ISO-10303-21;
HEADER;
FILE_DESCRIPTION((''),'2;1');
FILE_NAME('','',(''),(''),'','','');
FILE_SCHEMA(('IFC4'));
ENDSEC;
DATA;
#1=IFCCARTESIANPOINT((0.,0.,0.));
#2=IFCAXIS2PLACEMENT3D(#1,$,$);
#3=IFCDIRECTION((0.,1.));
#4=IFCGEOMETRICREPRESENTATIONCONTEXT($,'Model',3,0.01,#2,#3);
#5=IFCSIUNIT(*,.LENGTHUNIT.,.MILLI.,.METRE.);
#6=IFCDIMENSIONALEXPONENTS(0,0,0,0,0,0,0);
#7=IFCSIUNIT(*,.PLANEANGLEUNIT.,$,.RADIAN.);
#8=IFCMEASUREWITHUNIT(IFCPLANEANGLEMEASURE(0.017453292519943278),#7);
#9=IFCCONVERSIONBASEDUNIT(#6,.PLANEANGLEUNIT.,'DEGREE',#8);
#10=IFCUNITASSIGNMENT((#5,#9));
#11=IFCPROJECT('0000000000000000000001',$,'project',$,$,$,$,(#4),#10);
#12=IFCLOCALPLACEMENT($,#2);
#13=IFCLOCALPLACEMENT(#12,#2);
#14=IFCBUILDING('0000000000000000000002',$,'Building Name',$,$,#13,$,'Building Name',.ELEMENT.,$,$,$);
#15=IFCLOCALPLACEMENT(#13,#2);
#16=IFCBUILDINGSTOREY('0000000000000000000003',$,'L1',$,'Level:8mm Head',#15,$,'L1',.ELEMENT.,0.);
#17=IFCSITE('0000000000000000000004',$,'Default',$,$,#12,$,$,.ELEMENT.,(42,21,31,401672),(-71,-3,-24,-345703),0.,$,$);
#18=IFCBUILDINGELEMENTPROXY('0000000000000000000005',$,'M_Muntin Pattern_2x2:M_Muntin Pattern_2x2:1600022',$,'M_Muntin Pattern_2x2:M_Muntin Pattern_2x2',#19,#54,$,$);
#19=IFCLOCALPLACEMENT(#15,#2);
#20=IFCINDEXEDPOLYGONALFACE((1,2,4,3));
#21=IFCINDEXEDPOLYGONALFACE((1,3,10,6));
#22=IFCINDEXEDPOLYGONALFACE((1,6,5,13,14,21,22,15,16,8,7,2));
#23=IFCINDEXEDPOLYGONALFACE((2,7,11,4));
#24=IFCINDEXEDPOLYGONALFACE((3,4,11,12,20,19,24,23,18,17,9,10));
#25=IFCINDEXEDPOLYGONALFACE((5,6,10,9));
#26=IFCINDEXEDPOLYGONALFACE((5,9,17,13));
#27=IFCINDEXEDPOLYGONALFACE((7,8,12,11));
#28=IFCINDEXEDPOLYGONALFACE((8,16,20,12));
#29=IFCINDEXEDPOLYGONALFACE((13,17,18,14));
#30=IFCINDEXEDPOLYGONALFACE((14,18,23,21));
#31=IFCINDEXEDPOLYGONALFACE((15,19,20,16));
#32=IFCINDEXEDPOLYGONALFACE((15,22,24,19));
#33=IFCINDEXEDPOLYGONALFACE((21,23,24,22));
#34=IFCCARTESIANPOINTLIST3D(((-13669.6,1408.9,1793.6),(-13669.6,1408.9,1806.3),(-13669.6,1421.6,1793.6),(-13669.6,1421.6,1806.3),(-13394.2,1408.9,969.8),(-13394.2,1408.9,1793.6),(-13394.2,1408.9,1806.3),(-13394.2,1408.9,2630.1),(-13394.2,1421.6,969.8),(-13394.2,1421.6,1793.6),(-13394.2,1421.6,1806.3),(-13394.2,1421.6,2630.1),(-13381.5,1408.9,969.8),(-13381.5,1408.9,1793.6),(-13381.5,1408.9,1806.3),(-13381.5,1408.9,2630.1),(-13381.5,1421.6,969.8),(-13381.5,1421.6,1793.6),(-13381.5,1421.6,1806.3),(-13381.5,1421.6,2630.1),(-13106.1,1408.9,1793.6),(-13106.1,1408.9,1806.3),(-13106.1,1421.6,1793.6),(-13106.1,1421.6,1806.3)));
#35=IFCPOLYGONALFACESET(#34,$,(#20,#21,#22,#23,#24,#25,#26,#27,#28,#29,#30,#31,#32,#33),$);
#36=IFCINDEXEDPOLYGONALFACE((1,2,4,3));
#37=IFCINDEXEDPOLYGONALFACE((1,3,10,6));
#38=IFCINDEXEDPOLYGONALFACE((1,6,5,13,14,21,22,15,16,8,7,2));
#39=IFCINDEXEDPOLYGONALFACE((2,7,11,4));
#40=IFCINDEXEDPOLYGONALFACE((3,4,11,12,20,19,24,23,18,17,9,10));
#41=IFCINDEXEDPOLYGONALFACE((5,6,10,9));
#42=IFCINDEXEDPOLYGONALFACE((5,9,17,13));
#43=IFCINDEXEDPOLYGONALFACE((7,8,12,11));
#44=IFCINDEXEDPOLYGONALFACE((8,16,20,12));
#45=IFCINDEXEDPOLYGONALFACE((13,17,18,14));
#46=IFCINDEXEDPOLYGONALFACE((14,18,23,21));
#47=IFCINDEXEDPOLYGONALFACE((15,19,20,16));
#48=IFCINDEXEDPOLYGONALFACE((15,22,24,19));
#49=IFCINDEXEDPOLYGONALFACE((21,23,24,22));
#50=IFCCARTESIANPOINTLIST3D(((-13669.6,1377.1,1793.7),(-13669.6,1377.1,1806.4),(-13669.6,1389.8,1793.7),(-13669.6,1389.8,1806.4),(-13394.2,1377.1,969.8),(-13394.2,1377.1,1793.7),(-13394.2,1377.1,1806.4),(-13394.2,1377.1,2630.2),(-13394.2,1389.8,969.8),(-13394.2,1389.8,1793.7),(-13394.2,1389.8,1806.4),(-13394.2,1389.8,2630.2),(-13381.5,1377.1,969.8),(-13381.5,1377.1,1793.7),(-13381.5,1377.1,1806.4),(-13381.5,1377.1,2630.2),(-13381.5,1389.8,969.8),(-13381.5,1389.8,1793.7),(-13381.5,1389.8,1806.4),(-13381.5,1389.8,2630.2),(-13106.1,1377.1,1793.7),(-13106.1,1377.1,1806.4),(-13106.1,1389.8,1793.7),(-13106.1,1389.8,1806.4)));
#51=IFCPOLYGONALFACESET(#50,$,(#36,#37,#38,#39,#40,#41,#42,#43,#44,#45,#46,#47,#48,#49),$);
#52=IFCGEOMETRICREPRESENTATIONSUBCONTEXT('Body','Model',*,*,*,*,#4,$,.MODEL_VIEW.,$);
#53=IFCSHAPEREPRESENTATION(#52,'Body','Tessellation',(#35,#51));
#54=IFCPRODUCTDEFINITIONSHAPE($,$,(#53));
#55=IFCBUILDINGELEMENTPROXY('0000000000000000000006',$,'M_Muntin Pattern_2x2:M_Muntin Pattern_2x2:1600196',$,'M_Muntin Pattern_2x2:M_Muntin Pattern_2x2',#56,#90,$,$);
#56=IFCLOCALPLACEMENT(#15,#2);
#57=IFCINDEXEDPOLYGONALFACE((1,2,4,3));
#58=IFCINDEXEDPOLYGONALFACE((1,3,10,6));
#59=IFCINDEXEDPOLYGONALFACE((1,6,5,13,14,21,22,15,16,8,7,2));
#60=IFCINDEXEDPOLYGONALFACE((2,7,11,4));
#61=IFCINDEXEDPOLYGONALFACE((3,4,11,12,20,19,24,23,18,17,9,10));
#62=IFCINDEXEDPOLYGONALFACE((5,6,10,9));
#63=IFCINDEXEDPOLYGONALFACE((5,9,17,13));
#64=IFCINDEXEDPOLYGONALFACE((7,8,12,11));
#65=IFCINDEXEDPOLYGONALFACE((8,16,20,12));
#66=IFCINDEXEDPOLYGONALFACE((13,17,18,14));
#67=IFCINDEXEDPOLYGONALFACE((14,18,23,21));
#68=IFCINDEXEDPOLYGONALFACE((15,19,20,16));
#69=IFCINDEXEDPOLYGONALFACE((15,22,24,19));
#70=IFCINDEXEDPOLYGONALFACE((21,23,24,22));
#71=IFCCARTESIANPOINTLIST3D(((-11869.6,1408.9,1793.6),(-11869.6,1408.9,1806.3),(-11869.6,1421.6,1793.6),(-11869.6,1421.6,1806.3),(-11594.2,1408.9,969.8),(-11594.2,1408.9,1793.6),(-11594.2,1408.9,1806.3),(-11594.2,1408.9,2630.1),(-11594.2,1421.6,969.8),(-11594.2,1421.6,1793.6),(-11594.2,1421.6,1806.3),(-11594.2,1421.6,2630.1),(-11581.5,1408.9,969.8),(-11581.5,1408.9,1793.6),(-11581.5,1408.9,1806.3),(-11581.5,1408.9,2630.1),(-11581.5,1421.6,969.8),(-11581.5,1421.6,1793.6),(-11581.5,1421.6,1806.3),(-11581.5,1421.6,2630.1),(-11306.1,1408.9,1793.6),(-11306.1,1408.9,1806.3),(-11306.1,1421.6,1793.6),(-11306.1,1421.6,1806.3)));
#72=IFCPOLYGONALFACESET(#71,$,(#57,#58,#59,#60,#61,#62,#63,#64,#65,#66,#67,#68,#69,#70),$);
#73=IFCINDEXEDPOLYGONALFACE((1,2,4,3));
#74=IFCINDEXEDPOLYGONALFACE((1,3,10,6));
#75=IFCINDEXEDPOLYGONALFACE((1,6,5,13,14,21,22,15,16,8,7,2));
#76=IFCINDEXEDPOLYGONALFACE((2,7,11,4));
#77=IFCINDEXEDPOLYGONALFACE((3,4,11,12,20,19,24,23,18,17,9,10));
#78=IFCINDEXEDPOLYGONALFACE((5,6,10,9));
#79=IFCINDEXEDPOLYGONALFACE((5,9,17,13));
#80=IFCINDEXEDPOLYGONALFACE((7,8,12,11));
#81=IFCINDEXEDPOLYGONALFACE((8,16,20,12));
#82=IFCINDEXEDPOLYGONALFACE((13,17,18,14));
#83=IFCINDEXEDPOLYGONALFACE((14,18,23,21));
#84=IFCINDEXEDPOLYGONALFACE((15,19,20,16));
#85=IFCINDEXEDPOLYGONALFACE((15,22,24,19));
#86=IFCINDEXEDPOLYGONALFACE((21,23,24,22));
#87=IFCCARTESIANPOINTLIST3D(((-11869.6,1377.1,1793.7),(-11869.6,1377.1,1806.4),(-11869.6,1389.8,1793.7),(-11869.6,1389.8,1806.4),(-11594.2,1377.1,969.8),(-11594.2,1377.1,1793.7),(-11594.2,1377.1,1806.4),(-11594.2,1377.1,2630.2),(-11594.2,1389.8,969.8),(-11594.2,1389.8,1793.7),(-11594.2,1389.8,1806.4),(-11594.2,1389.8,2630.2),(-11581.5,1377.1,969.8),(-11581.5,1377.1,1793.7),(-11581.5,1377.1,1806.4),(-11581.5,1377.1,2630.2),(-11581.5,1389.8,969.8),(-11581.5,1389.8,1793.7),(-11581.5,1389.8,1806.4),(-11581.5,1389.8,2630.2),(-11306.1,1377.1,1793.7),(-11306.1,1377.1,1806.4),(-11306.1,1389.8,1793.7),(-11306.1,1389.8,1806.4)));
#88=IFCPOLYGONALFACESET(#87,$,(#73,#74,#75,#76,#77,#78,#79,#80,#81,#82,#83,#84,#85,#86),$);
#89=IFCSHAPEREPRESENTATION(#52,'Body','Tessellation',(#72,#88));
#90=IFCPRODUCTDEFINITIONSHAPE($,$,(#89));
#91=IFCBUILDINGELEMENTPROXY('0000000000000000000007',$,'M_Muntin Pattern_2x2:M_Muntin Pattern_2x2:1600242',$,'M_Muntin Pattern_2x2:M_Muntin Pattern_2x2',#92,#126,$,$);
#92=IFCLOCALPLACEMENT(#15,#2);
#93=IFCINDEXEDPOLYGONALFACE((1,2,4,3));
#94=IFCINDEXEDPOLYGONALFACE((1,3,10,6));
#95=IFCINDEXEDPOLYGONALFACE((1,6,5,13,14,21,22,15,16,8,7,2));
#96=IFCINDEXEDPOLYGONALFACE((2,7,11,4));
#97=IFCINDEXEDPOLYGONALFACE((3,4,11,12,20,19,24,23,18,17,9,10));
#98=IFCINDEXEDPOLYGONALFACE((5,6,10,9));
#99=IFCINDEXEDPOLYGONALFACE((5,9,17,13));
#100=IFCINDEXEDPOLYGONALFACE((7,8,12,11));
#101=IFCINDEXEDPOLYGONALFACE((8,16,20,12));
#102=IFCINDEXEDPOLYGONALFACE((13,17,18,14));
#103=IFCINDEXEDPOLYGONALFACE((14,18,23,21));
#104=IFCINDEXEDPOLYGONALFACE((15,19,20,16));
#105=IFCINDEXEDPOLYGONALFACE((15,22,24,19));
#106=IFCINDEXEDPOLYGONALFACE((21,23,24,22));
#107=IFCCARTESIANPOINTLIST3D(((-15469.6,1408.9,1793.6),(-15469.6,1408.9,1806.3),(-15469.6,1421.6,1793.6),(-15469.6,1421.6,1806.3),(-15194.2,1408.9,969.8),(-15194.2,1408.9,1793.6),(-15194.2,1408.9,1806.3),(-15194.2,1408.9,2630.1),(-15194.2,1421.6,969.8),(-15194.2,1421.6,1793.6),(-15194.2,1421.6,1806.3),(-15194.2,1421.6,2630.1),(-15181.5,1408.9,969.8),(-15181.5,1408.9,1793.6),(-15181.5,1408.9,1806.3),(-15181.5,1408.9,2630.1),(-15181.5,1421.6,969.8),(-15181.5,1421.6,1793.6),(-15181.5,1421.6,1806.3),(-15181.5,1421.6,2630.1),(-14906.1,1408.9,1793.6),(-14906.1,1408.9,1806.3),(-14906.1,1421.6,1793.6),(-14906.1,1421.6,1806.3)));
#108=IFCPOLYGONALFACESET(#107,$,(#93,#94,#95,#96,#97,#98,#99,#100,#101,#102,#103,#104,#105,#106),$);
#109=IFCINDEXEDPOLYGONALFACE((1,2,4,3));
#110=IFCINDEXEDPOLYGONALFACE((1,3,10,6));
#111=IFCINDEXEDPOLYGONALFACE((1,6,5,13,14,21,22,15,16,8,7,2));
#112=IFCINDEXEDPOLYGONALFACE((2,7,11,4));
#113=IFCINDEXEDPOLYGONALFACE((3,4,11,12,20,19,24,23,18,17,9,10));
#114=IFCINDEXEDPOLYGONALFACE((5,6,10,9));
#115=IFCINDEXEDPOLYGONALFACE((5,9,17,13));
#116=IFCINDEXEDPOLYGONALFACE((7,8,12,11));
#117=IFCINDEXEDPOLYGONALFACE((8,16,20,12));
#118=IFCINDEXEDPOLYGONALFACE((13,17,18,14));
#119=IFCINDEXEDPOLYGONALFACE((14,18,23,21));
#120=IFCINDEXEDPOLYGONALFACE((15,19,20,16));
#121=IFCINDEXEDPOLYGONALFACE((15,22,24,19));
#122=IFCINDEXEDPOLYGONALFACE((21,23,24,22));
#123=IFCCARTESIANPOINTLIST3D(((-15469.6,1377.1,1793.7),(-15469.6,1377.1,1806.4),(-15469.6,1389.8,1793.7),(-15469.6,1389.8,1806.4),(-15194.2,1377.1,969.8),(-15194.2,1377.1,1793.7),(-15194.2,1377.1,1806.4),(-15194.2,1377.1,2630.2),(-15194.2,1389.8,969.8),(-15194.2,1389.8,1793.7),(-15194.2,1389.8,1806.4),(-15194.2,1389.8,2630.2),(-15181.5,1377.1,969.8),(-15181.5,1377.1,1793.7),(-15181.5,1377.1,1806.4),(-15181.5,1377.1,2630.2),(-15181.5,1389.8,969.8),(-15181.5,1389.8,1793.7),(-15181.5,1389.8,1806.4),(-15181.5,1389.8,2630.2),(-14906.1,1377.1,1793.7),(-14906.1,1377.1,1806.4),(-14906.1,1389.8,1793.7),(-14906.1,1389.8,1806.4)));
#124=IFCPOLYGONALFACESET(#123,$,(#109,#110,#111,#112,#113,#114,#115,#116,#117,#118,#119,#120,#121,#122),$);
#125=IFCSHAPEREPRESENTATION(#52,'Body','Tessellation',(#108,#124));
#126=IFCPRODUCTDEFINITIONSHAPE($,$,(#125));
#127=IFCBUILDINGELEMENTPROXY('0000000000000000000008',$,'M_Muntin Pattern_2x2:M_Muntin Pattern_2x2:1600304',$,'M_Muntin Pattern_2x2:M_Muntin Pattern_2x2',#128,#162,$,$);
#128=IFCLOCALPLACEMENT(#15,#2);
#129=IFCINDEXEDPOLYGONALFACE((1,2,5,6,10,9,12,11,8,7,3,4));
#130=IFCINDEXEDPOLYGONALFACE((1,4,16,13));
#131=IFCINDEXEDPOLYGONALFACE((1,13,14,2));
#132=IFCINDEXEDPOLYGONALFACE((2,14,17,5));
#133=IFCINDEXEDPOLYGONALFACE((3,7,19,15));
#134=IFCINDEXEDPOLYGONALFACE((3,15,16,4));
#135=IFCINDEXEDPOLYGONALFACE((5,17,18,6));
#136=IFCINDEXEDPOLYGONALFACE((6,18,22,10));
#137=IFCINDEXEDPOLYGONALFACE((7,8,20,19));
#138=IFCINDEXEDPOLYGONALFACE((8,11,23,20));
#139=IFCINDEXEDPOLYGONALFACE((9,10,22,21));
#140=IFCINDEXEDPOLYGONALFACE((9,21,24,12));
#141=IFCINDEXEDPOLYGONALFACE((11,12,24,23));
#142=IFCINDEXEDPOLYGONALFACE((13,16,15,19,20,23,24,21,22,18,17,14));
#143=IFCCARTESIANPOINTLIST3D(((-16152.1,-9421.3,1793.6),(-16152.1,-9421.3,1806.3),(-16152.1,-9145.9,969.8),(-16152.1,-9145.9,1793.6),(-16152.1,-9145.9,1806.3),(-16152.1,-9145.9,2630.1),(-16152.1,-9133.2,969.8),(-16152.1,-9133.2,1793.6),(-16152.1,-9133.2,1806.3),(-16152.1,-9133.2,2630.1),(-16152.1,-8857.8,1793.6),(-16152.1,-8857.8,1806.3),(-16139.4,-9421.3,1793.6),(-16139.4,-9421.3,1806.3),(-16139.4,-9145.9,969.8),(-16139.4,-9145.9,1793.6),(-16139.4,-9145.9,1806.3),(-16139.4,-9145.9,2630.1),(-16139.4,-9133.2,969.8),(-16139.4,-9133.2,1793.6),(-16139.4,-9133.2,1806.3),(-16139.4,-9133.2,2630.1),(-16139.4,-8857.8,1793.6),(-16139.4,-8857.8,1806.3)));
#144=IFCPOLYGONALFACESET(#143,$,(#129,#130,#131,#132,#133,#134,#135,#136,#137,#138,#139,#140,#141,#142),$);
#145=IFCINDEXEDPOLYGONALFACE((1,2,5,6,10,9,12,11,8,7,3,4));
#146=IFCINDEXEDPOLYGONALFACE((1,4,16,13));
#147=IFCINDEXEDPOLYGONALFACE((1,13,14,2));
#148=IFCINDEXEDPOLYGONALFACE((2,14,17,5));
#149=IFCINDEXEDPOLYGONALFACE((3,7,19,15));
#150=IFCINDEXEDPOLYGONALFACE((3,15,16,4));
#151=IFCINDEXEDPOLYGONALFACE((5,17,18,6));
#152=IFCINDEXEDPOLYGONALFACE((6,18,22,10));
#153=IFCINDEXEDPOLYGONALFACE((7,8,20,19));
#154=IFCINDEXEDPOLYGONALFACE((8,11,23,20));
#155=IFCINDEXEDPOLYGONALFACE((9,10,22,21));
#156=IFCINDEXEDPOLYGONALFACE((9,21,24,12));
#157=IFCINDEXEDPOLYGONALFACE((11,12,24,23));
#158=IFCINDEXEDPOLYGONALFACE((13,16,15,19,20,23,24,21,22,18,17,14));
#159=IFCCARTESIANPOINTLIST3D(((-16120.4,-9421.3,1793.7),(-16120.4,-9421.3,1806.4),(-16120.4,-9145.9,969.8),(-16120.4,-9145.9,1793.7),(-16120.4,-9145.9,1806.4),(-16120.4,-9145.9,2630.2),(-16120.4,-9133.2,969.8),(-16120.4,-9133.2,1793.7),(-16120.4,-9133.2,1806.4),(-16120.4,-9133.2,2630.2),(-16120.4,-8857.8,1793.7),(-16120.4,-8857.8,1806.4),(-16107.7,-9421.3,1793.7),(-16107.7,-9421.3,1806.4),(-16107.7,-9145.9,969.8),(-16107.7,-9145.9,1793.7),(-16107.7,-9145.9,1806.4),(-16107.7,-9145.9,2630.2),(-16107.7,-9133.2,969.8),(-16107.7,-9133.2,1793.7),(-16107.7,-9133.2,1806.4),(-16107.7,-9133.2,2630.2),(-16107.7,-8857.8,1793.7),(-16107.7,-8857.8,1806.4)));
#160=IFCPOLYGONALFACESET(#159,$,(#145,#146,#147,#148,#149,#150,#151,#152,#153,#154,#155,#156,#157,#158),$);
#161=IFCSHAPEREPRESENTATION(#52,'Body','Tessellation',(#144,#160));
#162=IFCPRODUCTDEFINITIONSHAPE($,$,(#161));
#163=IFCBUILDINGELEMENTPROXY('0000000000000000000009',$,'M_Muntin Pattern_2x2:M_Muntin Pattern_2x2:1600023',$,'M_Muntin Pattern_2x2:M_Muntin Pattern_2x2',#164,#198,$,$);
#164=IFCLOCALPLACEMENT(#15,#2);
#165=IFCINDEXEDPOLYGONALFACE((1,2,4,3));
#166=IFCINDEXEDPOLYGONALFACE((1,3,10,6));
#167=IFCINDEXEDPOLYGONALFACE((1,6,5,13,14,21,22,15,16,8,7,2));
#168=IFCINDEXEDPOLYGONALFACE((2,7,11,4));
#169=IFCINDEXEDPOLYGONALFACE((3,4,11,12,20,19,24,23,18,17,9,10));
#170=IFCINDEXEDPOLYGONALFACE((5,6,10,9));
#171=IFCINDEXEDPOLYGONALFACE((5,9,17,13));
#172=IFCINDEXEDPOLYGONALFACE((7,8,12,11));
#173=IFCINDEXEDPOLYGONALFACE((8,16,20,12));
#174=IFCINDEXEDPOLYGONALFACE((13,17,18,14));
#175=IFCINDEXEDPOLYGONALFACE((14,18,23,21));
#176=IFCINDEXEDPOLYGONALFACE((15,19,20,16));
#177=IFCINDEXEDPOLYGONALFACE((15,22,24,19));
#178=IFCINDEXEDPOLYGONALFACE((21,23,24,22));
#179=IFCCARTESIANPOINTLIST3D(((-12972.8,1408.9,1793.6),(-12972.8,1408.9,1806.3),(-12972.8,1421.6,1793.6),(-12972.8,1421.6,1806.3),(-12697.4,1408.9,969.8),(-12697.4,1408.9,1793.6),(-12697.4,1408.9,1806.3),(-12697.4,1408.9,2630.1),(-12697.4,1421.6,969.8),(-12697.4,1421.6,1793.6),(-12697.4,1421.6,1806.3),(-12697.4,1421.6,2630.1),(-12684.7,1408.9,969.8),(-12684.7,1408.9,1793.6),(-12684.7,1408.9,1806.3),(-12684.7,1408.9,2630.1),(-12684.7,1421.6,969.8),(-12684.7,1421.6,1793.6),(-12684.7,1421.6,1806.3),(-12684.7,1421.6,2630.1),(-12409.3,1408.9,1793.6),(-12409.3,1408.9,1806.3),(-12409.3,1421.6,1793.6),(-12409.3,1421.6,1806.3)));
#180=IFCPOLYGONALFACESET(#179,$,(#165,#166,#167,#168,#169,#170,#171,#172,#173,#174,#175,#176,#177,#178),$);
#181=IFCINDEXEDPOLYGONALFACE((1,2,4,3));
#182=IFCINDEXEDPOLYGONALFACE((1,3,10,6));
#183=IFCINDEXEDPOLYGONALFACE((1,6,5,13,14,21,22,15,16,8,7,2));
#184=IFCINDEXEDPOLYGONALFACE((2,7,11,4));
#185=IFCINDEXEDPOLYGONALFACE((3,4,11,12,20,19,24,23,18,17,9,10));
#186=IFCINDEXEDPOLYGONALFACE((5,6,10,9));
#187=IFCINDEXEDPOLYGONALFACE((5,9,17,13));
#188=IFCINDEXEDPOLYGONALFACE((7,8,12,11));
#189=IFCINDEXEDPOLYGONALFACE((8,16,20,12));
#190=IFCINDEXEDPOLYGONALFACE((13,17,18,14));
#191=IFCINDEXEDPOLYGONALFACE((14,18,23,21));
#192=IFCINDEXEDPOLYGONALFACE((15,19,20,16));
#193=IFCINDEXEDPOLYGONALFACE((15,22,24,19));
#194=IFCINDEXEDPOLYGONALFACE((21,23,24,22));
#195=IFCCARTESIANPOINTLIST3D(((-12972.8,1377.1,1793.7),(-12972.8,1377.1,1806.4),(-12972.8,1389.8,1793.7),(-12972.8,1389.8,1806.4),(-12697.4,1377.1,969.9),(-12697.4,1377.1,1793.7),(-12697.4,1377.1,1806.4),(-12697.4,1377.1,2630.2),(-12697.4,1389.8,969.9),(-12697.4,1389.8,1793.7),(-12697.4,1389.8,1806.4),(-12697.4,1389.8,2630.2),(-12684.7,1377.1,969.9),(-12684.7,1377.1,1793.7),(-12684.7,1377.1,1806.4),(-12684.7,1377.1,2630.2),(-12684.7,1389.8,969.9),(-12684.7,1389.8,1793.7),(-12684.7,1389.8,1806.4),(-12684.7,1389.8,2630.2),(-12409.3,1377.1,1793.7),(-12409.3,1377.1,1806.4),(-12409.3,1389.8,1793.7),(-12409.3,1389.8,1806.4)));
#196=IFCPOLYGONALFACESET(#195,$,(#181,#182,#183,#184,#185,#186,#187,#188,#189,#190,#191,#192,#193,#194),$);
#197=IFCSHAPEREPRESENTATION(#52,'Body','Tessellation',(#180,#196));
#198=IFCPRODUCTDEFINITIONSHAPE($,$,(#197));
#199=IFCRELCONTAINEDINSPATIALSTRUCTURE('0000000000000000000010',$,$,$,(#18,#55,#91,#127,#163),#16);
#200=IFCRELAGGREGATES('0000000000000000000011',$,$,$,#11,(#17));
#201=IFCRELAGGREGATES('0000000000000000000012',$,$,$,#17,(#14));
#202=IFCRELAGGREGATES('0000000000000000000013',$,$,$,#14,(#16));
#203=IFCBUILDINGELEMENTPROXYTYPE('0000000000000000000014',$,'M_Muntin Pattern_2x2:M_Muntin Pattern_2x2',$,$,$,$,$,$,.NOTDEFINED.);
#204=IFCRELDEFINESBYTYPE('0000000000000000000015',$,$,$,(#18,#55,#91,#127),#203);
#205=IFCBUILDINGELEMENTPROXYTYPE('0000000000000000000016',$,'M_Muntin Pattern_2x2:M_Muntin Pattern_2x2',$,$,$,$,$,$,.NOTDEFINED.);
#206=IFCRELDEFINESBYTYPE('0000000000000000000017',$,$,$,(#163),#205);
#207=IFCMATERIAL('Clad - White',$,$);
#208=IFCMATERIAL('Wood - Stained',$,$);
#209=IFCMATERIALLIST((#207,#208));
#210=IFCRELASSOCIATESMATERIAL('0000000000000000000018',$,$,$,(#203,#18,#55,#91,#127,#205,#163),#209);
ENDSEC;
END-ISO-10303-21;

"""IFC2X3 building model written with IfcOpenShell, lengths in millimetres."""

from ifc_helpers import new_model, entity, si_unit, converted_unit, direction, frame, origin, place, context, subcontext, project, spatial, polyline, outline, extrude, source, transform, mapped, material, material_list, type_object, type_shapes, element, save


model = new_model("IFC2X3")

# Units and contexts
model_context = context("Model", 3, precision=0.01, world=origin(), true_north=direction((0.0, 1.0)))
body_context = subcontext(model_context, "Body", "Model", "MODEL_VIEW")
ifc_project = project(units=[si_unit("LENGTHUNIT", "METRE", prefix="MILLI"), converted_unit("PLANEANGLEUNIT", "DEGREE", entity("IfcPlaneAngleMeasure", 0.017453292519943278), si_unit("PLANEANGLEUNIT", "RADIAN"), dimensions=[0, 0, 0, 0, 0, 0, 0])], contexts=[model_context])

# Site, building, storey
site_placement = place(None, origin())
site = spatial("IfcSite", under=ifc_project, at=site_placement, Name="Default", CompositionType="ELEMENT", RefLatitude=(42, 21, 31, 401672), RefLongitude=(-71, -3, -24, -345703), RefElevation=0.0)
building_placement = place(site_placement, origin())
building = spatial("IfcBuilding", under=site, at=building_placement, Name="Building Name", LongName="Building Name", CompositionType="ELEMENT")
storey_placement = place(building_placement, origin())
storey = spatial("IfcBuildingStorey", under=building, at=storey_placement, Name="L1", ObjectType="Level:8mm Head", LongName="L1", CompositionType="ELEMENT", Elevation=0.0)

# Building element proxies
ifc_material_1 = material(Name="Clad - White")
ifc_material_2 = material(Name="Wood - Stained")
ifc_material_list = material_list([ifc_material_1, ifc_material_2])
building_element_proxy_type_1 = type_object("IfcBuildingElementProxyType", Name="M_Muntin Pattern_2x2:M_Muntin Pattern_2x2", PredefinedType="NOTDEFINED", material=ifc_material_list)
shared_shape_1 = source(origin(), body_context, "Body", "SweptSolid", [
    extrude(outline(polyline([(6.4, -6.4), (830.1, -6.4), (830.1, 6.3), (6.4, 6.3), (6.4, 281.7), (-6.3, 281.7), (-6.3, 6.3), (-830.2, 6.3), (-830.2, -6.4), (-6.3, -6.4), (-6.3, -281.7), (6.4, -281.7), (6.4, -6.4)])), frame((0.0, 9.5, 830.1), z_axis=(0.0, 1.0, 0.0), x_axis=(0.0, 0.0, 1.0)), (0.0, 0.0, 1.0), 12.7),
    extrude(outline(polyline([(6.4, -6.4), (830.2, -6.4), (830.2, 6.3), (6.4, 6.3), (6.4, 281.7), (-6.3, 281.7), (-6.3, 6.3), (-830.2, 6.3), (-830.2, -6.4), (-6.3, -6.4), (-6.3, -281.7), (6.4, -281.7), (6.4, -6.4)])), frame((0.0, -22.2, 830.2), z_axis=(0.0, 1.0, 0.0), x_axis=(0.0, 0.0, 1.0)), (0.0, 0.0, 1.0), 12.7),
])
type_shapes(building_element_proxy_type_1, [shared_shape_1])
for number, where, name in (
    (1, (-13387.9, 1399.4, 969.8), "M_Muntin Pattern_2x2:M_Muntin Pattern_2x2:1600022"),
    (2, (-11587.9, 1399.4, 969.8), "M_Muntin Pattern_2x2:M_Muntin Pattern_2x2:1600196"),
    (3, (-15187.9, 1399.4, 969.8), "M_Muntin Pattern_2x2:M_Muntin Pattern_2x2:1600242"),
):
    element("IfcBuildingElementProxy", number, at=place(storey_placement, frame(where)), inside=storey, type_object=building_element_proxy_type_1, material=ifc_material_list, Name=name, ObjectType="M_Muntin Pattern_2x2:M_Muntin Pattern_2x2", context=body_context, shape_type="MappedRepresentation", body=[
        mapped(shared_shape_1, transform((0.0, 0.0, 0.0), scale=1.0)),
    ])
proxy_placement = place(storey_placement, frame((-16129.9, -9139.5, 969.8), z_axis=(0.0, 0.0, 1.0), x_axis=(0.0, 1.0, 0.0)))
element("IfcBuildingElementProxy", 4, at=proxy_placement, inside=storey, type_object=building_element_proxy_type_1, material=ifc_material_list, Name="M_Muntin Pattern_2x2:M_Muntin Pattern_2x2:1600304", ObjectType="M_Muntin Pattern_2x2:M_Muntin Pattern_2x2", context=body_context, shape_type="MappedRepresentation", body=[
    mapped(shared_shape_1, transform((0.0, 0.0, 0.0), scale=1.0)),
])
building_element_proxy_type_2 = type_object("IfcBuildingElementProxyType", Name="M_Muntin Pattern_2x2:M_Muntin Pattern_2x2", PredefinedType="NOTDEFINED", material=ifc_material_list)
shared_shape_2 = source(origin(), body_context, "Body", "SweptSolid", [
    extrude(outline(polyline([(6.4, -6.4), (830.1, -6.4), (830.1, 6.3), (6.4, 6.3), (6.4, 281.7), (-6.3, 281.7), (-6.3, 6.3), (-830.2, 6.3), (-830.2, -6.4), (-6.3, -6.4), (-6.3, -281.7), (6.4, -281.7), (6.4, -6.4)])), frame((0.0, -22.2, 830.1), z_axis=(0.0, 1.0, 0.0), x_axis=(0.0, 0.0, 1.0)), (0.0, 0.0, 1.0), 12.7),
    extrude(outline(polyline([(6.4, -6.4), (830.2, -6.4), (830.2, 6.3), (6.4, 6.3), (6.4, 281.7), (-6.3, 281.7), (-6.3, 6.3), (-830.2, 6.3), (-830.2, -6.4), (-6.3, -6.4), (-6.3, -281.7), (6.4, -281.7), (6.4, -6.4)])), frame((0.0, 9.5, 830.2), z_axis=(0.0, 1.0, 0.0), x_axis=(0.0, 0.0, 1.0)), (0.0, 0.0, 1.0), 12.7),
])
type_shapes(building_element_proxy_type_2, [shared_shape_2])
for number, where, z_axis, x_axis, name in (
    (5, (-12691.0, 1399.4, 969.9), (0.0, 0.0, 1.0), (-1.0, 0.0, 0.0), "M_Muntin Pattern_2x2:M_Muntin Pattern_2x2:1600023"),
):
    element("IfcBuildingElementProxy", number, at=place(storey_placement, frame(where, z_axis=z_axis, x_axis=x_axis)), inside=storey, type_object=building_element_proxy_type_2, material=ifc_material_list, Name=name, ObjectType="M_Muntin Pattern_2x2:M_Muntin Pattern_2x2", context=body_context, shape_type="MappedRepresentation", body=[
        mapped(shared_shape_2, transform((0.0, 0.0, 0.0), scale=1.0)),
    ])

save(model, "model.ifc")
